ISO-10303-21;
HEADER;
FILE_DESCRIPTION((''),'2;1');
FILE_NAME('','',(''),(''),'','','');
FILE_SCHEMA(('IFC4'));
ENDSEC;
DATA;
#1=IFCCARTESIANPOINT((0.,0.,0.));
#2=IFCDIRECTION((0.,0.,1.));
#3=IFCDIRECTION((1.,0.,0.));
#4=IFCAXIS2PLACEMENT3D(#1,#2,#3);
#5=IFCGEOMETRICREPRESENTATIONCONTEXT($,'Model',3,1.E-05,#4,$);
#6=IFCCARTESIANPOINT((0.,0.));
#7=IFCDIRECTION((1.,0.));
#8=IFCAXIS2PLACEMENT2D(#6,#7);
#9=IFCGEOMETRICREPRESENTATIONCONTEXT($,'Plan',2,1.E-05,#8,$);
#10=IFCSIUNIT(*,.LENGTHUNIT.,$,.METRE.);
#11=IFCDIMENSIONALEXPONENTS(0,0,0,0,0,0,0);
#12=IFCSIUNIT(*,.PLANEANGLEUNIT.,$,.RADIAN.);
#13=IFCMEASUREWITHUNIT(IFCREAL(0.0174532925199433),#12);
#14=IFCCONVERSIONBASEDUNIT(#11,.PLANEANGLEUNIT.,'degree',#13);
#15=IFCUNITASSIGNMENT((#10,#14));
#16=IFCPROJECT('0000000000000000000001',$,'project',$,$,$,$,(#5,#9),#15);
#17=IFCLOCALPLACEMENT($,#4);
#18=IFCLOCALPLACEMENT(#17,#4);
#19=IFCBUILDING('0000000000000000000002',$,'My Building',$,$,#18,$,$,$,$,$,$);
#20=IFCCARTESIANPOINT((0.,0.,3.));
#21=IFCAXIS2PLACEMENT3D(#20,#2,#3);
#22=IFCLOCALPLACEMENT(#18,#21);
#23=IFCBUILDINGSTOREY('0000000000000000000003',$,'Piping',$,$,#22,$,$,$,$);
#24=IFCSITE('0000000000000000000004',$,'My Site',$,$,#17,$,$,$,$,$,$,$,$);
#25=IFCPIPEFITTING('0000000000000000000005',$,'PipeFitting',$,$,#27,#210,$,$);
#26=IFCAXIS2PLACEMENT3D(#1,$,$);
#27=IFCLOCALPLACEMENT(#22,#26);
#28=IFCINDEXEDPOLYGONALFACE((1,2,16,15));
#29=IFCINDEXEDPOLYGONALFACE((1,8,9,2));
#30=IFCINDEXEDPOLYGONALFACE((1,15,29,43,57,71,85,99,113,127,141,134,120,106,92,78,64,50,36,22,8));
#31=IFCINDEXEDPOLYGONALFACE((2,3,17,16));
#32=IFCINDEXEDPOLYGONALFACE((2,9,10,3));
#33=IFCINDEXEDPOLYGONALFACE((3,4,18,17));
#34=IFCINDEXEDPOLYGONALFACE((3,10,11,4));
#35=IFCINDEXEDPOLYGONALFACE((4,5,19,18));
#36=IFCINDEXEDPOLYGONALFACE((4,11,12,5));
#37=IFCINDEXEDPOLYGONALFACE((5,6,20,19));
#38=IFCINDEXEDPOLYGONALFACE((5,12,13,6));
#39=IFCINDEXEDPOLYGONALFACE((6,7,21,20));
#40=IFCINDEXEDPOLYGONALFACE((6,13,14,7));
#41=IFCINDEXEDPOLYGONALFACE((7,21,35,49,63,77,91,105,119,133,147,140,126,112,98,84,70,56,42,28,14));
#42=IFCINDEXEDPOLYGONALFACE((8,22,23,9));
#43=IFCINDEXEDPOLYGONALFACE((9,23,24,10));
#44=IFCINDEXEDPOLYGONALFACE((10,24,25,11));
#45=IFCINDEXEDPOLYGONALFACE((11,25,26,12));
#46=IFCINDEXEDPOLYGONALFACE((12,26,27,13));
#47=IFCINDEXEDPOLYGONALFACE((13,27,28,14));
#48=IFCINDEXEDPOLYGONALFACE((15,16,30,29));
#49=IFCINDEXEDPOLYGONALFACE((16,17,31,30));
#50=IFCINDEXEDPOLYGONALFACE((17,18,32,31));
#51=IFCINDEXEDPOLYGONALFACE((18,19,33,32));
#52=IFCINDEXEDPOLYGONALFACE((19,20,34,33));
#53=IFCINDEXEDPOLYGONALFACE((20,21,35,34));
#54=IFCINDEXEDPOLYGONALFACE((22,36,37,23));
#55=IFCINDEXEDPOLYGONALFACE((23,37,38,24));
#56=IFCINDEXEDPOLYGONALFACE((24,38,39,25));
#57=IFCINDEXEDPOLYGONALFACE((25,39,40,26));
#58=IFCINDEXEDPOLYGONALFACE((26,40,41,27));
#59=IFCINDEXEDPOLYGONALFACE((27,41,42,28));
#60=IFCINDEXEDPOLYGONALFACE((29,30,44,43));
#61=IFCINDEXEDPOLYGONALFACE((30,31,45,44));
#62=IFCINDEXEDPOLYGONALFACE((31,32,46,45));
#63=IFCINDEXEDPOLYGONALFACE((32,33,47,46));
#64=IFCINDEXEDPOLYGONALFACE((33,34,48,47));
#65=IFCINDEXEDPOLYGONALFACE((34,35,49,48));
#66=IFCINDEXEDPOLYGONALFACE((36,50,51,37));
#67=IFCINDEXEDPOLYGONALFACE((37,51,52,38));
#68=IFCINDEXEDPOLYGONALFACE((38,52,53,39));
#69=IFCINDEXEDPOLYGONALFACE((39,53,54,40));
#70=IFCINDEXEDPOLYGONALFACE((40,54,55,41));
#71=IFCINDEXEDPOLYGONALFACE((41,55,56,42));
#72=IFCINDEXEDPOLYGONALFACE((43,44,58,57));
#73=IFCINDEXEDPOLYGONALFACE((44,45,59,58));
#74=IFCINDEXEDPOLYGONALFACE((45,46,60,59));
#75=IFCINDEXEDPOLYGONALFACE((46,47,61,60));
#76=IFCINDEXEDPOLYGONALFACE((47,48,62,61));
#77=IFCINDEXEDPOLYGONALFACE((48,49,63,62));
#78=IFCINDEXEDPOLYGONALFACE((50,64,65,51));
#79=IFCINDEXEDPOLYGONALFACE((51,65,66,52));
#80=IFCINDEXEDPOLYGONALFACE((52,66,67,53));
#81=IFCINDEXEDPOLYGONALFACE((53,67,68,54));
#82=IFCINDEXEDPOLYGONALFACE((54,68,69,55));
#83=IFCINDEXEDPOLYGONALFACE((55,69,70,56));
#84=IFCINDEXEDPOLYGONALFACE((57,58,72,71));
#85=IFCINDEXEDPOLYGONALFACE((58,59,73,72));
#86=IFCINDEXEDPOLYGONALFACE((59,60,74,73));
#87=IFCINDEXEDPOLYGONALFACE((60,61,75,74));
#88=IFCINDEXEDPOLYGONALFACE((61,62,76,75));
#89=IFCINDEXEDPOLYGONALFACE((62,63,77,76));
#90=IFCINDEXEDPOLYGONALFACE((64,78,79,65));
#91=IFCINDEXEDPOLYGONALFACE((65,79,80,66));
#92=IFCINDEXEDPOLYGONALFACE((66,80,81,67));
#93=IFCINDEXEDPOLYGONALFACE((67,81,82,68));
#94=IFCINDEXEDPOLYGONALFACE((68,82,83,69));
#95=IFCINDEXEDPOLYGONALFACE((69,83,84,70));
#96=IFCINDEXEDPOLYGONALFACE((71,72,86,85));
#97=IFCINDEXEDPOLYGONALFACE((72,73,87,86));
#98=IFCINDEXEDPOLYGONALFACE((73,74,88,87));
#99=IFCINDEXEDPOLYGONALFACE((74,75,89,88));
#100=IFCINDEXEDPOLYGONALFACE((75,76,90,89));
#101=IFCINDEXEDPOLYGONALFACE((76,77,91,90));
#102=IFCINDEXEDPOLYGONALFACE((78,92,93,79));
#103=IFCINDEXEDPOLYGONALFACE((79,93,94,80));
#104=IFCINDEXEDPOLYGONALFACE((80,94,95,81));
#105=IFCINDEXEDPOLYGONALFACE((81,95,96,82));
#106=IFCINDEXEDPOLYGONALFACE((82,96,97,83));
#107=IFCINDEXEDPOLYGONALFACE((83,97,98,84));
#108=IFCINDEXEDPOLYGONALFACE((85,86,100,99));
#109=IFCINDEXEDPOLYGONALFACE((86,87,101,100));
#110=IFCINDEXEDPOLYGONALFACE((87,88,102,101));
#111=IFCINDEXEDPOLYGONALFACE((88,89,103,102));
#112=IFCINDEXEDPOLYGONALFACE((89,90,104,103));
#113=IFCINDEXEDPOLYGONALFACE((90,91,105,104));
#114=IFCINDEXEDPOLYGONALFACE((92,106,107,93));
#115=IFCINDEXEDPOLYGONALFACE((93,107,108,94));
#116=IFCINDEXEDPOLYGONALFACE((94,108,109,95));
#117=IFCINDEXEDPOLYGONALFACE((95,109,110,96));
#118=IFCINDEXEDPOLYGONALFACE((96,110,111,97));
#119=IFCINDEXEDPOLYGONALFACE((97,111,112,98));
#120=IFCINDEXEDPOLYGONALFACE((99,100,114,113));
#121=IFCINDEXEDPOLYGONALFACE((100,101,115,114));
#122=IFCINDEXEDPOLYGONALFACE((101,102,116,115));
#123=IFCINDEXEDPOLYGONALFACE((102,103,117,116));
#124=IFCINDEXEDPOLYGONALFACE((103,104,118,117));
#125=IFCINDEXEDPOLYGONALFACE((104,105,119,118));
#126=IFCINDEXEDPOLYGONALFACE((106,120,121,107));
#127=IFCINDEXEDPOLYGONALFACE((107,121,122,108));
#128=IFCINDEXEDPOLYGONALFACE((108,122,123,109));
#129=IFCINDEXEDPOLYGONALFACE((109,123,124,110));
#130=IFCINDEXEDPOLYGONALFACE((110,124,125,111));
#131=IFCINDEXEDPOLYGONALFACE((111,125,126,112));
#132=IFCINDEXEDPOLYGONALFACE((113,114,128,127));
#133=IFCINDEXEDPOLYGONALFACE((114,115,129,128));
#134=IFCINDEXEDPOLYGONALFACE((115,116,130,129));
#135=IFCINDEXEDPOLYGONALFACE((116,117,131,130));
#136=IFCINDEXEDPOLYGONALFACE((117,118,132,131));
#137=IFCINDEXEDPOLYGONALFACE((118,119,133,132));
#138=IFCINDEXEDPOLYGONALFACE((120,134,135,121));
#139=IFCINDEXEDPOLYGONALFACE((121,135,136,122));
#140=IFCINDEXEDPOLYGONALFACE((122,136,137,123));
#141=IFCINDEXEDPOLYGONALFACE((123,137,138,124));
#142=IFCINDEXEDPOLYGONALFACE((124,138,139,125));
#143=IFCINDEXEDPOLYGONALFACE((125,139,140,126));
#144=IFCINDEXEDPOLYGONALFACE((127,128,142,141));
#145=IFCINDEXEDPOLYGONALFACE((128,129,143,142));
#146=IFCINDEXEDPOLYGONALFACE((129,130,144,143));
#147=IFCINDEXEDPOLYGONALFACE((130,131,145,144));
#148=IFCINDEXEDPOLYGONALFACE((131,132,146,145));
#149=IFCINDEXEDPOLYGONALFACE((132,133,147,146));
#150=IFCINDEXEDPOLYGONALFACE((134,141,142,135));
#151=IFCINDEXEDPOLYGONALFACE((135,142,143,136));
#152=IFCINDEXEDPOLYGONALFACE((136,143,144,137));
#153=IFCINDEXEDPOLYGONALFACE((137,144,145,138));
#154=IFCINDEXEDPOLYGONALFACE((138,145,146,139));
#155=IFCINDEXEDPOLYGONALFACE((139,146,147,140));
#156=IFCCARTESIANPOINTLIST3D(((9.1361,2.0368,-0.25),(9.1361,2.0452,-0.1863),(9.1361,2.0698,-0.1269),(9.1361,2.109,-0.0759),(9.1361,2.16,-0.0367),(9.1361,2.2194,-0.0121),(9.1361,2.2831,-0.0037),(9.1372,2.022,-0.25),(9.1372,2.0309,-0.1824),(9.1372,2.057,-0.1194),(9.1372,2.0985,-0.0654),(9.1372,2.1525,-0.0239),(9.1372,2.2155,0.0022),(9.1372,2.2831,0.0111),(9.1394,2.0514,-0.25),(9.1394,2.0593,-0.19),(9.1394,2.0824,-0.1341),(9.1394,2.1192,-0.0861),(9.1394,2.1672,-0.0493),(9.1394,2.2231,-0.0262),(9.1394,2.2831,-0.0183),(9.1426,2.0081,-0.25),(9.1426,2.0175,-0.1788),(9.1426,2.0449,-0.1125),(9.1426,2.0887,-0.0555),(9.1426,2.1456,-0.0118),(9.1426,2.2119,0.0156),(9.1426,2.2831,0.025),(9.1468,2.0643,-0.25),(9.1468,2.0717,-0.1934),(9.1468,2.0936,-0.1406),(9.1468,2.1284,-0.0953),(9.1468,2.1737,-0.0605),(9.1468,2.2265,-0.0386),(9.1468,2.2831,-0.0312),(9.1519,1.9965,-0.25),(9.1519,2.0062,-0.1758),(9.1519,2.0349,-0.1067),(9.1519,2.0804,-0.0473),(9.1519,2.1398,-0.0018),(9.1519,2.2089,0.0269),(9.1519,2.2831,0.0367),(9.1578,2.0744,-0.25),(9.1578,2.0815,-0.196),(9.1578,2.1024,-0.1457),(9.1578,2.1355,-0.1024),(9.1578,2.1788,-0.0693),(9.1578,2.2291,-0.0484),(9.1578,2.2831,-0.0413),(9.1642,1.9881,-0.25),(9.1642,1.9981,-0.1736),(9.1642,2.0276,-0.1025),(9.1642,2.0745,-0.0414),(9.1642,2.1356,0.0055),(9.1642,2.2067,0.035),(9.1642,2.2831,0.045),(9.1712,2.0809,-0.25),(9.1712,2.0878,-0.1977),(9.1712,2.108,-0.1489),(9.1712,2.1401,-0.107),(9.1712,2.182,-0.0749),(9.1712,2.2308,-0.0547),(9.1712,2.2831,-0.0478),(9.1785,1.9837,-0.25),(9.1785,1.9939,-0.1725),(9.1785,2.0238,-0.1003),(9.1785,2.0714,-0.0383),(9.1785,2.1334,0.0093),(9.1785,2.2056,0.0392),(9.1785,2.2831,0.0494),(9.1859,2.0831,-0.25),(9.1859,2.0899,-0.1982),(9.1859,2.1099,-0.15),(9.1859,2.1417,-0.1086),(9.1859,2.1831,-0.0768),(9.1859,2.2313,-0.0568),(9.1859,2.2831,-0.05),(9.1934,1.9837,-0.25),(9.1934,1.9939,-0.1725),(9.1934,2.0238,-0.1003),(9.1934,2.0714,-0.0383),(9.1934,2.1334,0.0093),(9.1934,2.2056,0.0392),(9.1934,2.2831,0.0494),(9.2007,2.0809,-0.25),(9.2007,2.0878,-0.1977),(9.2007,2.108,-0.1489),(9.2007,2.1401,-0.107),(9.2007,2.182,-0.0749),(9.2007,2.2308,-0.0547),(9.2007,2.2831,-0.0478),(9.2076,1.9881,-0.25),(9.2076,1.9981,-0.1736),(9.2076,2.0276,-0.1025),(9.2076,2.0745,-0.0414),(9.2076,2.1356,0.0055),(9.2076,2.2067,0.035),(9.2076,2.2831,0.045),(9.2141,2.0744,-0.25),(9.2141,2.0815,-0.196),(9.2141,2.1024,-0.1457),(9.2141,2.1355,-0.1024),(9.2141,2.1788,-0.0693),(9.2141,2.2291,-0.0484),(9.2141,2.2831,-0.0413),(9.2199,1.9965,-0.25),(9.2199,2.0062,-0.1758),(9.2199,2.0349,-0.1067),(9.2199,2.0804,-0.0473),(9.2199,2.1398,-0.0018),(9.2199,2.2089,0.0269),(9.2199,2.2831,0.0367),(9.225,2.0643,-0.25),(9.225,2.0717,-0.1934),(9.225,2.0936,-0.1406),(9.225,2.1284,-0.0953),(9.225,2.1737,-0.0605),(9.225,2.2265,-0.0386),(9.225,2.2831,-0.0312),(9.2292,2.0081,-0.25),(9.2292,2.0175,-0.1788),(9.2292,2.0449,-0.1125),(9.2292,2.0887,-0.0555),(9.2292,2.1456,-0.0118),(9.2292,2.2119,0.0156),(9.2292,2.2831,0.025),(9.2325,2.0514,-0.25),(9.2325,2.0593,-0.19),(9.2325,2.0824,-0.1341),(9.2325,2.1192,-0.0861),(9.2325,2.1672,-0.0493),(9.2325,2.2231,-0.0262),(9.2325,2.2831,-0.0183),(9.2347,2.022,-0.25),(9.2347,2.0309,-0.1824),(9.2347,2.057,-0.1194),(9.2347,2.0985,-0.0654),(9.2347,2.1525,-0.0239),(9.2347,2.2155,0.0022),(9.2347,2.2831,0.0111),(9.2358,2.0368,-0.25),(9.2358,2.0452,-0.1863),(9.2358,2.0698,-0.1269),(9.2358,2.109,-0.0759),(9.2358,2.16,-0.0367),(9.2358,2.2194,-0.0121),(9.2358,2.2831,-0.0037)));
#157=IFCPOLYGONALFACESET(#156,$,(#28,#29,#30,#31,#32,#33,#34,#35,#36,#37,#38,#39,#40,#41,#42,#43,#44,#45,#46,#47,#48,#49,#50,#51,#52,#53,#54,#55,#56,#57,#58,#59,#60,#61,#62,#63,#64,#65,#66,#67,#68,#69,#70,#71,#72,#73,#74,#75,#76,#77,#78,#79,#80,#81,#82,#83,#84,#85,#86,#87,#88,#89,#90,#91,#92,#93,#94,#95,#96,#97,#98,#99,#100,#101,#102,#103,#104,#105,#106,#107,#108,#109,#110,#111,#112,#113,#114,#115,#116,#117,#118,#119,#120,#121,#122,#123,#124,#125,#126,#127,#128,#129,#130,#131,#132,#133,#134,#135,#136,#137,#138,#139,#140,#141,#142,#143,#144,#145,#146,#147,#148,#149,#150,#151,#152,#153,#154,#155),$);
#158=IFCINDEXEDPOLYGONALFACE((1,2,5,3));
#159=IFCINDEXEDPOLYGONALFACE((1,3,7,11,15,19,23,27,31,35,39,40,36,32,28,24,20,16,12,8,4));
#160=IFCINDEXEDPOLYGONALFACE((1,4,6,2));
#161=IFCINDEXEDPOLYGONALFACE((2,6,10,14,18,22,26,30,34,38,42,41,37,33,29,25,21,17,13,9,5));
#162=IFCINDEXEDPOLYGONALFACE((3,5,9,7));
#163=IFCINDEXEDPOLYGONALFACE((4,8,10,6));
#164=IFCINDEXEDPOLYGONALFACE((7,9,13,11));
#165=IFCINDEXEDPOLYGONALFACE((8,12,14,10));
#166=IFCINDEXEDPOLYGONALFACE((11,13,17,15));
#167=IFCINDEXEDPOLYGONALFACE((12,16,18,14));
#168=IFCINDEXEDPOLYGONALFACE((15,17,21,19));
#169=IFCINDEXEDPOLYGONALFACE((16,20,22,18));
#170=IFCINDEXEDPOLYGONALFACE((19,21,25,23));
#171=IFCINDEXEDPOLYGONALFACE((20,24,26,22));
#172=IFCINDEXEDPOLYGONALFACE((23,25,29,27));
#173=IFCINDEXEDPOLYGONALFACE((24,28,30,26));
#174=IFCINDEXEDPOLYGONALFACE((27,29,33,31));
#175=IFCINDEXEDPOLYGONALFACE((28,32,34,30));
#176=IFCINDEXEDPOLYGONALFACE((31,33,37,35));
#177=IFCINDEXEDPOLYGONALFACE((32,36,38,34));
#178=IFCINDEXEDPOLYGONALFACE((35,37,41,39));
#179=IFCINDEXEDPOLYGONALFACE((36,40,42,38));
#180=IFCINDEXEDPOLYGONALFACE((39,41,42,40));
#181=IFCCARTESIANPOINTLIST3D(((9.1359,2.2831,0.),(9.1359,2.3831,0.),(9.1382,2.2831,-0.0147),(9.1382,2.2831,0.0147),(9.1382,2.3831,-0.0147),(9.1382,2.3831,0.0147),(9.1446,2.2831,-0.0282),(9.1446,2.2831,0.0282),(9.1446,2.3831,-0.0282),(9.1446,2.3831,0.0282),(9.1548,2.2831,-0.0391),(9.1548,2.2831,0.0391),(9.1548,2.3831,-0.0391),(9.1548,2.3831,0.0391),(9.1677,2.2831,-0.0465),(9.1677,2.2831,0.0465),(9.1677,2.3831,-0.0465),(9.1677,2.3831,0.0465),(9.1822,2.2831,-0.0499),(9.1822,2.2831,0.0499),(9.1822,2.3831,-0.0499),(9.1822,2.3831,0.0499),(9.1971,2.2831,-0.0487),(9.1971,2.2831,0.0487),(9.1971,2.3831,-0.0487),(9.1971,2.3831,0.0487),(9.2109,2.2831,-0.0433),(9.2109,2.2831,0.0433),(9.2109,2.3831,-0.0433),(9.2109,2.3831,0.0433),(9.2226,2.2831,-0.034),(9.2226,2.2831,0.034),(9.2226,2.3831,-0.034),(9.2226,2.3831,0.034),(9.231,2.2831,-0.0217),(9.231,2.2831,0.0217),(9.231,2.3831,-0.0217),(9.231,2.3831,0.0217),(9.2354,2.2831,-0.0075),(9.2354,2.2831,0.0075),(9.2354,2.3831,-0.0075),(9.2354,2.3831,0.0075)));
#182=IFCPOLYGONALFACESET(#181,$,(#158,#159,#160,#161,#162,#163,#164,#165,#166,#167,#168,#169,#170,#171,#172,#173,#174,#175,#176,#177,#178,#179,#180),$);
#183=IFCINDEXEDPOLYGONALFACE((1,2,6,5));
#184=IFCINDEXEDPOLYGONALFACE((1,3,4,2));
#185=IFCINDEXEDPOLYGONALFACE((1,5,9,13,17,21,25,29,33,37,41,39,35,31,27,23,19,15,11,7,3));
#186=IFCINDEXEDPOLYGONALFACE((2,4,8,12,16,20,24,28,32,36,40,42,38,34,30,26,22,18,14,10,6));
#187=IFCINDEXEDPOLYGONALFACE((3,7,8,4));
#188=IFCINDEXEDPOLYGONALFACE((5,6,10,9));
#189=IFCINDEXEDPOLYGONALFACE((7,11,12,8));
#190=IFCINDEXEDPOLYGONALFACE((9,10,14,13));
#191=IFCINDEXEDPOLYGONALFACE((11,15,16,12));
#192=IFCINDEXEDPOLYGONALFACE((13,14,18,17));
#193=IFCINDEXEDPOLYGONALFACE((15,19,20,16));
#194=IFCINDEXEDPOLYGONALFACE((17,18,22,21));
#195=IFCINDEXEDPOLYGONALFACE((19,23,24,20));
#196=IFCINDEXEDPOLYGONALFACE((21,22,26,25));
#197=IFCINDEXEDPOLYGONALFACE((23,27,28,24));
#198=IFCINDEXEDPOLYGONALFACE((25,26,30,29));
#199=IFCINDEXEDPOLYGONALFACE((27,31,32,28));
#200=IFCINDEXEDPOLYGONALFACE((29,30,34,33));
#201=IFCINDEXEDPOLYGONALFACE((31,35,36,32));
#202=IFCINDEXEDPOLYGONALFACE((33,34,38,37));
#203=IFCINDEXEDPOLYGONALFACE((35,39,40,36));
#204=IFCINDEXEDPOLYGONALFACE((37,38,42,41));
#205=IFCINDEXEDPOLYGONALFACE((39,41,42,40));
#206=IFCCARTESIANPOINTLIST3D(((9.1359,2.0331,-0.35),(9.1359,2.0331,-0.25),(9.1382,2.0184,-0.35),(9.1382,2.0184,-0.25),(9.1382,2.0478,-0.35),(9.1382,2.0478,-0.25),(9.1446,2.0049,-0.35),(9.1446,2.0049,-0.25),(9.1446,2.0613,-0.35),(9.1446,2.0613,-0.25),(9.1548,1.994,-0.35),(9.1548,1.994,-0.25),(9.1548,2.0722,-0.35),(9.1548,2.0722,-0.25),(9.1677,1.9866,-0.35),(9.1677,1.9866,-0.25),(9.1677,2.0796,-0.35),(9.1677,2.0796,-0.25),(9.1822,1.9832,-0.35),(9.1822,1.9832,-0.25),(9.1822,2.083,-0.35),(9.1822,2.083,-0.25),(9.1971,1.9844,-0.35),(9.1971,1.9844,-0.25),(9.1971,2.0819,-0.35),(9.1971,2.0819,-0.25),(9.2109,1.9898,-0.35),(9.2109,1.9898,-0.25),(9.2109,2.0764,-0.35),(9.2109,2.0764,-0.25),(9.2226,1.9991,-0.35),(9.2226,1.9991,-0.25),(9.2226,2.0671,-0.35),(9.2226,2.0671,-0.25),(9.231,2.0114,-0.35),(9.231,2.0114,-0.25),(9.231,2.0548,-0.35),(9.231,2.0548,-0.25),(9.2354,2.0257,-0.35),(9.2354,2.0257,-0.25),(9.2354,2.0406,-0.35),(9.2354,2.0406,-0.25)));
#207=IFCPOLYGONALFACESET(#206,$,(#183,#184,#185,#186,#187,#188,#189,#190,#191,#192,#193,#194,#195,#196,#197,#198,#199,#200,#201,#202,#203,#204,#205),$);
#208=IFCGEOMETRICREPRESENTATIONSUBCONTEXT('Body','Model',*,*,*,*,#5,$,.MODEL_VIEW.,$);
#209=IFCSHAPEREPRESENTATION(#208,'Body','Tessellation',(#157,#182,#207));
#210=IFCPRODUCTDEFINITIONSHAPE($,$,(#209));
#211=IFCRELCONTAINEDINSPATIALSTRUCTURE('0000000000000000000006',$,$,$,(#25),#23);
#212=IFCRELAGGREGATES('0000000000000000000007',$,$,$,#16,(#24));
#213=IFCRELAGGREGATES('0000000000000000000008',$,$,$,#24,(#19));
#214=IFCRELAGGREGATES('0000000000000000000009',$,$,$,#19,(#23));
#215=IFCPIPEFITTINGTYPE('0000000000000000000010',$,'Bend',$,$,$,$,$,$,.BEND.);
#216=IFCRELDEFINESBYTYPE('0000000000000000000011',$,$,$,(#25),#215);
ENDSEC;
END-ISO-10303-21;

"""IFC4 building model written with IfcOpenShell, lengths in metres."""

from ifc_helpers import new_model, entity, si_unit, converted_unit, frame, origin_with_axes, origin_2d_with_axis, place, context, subcontext, project, spatial, circle, extrude, source, transform, mapped, type_object, type_shapes, element, save


model = new_model("IFC4")

# Units and contexts
model_context = context("Model", 3, precision=1e-05, world=origin_with_axes())
plan_context = context("Plan", 2, precision=1e-05, world=origin_2d_with_axis())
body_context = subcontext(model_context, "Body", "Model", "MODEL_VIEW")
ifc_project = project(units=[si_unit("LENGTHUNIT", "METRE"), converted_unit("PLANEANGLEUNIT", "degree", entity("IfcReal", 0.0174532925199433), si_unit("PLANEANGLEUNIT", "RADIAN"), dimensions=[0, 0, 0, 0, 0, 0, 0])], contexts=[model_context, plan_context])

# Site, building, storey
site_placement = place(None, origin_with_axes())
site = spatial("IfcSite", under=ifc_project, at=site_placement, Name="My Site")
building_placement = place(site_placement, origin_with_axes())
building = spatial("IfcBuilding", under=site, at=building_placement, Name="My Building")
storey_placement = place(building_placement, frame((0.0, 0.0, 3.0), z_axis=(0.0, 0.0, 1.0), x_axis=(1.0, 0.0, 0.0)))
storey = spatial("IfcBuildingStorey", under=building, at=storey_placement, Name="Piping")

# Pipe fitting
pipe_fitting_type = type_object("IfcPipeFittingType", Name="Bend", PredefinedType="BEND")
shared_shape = source(origin_with_axes(), body_context, "Body", "SolidModel", [
    entity("IfcSweptDiskSolid", entity("IfcIndexedPolyCurve", entity("IfcCartesianPointList3D", [[0.0, 0.0, -0.1], [0.0, -0.0732, -0.2768], [0.0, -0.25, -0.35]]), [entity("IfcArcIndex", [1, 2, 3])]), 0.05),
    extrude(circle(Radius=0.05), origin_with_axes(), (0.0, 0.0, -1.0), 0.1),
    extrude(circle(Radius=0.05), frame((0.0, -0.25, -0.35), z_axis=(0.0, -1.0, 0.0), x_axis=(1.0, 0.0, 0.0)), (0.0, 0.0, 1.0), 0.1),
])
type_shapes(pipe_fitting_type, [shared_shape])
for number, where, z_axis, x_axis, name in (
    (1, (9.1859, 2.3831, 0.0), (0.0, 1.0, 0.0), (-1.0, 0.0, 0.0), "PipeFitting"),
):
    element("IfcPipeFitting", number, at=place(storey_placement, frame(where, z_axis=z_axis, x_axis=x_axis)), inside=storey, type_object=pipe_fitting_type, Name=name, context=body_context, shape_type="MappedRepresentation", body=[
        mapped(shared_shape, transform((0.0, 0.0, 0.0), x_axis=(1.0, 0.0, 0.0), y_axis=(0.0, 1.0, 0.0), z_axis=(0.0, 0.0, 1.0), scale=1.0)),
    ])

save(model, "model.ifc")
